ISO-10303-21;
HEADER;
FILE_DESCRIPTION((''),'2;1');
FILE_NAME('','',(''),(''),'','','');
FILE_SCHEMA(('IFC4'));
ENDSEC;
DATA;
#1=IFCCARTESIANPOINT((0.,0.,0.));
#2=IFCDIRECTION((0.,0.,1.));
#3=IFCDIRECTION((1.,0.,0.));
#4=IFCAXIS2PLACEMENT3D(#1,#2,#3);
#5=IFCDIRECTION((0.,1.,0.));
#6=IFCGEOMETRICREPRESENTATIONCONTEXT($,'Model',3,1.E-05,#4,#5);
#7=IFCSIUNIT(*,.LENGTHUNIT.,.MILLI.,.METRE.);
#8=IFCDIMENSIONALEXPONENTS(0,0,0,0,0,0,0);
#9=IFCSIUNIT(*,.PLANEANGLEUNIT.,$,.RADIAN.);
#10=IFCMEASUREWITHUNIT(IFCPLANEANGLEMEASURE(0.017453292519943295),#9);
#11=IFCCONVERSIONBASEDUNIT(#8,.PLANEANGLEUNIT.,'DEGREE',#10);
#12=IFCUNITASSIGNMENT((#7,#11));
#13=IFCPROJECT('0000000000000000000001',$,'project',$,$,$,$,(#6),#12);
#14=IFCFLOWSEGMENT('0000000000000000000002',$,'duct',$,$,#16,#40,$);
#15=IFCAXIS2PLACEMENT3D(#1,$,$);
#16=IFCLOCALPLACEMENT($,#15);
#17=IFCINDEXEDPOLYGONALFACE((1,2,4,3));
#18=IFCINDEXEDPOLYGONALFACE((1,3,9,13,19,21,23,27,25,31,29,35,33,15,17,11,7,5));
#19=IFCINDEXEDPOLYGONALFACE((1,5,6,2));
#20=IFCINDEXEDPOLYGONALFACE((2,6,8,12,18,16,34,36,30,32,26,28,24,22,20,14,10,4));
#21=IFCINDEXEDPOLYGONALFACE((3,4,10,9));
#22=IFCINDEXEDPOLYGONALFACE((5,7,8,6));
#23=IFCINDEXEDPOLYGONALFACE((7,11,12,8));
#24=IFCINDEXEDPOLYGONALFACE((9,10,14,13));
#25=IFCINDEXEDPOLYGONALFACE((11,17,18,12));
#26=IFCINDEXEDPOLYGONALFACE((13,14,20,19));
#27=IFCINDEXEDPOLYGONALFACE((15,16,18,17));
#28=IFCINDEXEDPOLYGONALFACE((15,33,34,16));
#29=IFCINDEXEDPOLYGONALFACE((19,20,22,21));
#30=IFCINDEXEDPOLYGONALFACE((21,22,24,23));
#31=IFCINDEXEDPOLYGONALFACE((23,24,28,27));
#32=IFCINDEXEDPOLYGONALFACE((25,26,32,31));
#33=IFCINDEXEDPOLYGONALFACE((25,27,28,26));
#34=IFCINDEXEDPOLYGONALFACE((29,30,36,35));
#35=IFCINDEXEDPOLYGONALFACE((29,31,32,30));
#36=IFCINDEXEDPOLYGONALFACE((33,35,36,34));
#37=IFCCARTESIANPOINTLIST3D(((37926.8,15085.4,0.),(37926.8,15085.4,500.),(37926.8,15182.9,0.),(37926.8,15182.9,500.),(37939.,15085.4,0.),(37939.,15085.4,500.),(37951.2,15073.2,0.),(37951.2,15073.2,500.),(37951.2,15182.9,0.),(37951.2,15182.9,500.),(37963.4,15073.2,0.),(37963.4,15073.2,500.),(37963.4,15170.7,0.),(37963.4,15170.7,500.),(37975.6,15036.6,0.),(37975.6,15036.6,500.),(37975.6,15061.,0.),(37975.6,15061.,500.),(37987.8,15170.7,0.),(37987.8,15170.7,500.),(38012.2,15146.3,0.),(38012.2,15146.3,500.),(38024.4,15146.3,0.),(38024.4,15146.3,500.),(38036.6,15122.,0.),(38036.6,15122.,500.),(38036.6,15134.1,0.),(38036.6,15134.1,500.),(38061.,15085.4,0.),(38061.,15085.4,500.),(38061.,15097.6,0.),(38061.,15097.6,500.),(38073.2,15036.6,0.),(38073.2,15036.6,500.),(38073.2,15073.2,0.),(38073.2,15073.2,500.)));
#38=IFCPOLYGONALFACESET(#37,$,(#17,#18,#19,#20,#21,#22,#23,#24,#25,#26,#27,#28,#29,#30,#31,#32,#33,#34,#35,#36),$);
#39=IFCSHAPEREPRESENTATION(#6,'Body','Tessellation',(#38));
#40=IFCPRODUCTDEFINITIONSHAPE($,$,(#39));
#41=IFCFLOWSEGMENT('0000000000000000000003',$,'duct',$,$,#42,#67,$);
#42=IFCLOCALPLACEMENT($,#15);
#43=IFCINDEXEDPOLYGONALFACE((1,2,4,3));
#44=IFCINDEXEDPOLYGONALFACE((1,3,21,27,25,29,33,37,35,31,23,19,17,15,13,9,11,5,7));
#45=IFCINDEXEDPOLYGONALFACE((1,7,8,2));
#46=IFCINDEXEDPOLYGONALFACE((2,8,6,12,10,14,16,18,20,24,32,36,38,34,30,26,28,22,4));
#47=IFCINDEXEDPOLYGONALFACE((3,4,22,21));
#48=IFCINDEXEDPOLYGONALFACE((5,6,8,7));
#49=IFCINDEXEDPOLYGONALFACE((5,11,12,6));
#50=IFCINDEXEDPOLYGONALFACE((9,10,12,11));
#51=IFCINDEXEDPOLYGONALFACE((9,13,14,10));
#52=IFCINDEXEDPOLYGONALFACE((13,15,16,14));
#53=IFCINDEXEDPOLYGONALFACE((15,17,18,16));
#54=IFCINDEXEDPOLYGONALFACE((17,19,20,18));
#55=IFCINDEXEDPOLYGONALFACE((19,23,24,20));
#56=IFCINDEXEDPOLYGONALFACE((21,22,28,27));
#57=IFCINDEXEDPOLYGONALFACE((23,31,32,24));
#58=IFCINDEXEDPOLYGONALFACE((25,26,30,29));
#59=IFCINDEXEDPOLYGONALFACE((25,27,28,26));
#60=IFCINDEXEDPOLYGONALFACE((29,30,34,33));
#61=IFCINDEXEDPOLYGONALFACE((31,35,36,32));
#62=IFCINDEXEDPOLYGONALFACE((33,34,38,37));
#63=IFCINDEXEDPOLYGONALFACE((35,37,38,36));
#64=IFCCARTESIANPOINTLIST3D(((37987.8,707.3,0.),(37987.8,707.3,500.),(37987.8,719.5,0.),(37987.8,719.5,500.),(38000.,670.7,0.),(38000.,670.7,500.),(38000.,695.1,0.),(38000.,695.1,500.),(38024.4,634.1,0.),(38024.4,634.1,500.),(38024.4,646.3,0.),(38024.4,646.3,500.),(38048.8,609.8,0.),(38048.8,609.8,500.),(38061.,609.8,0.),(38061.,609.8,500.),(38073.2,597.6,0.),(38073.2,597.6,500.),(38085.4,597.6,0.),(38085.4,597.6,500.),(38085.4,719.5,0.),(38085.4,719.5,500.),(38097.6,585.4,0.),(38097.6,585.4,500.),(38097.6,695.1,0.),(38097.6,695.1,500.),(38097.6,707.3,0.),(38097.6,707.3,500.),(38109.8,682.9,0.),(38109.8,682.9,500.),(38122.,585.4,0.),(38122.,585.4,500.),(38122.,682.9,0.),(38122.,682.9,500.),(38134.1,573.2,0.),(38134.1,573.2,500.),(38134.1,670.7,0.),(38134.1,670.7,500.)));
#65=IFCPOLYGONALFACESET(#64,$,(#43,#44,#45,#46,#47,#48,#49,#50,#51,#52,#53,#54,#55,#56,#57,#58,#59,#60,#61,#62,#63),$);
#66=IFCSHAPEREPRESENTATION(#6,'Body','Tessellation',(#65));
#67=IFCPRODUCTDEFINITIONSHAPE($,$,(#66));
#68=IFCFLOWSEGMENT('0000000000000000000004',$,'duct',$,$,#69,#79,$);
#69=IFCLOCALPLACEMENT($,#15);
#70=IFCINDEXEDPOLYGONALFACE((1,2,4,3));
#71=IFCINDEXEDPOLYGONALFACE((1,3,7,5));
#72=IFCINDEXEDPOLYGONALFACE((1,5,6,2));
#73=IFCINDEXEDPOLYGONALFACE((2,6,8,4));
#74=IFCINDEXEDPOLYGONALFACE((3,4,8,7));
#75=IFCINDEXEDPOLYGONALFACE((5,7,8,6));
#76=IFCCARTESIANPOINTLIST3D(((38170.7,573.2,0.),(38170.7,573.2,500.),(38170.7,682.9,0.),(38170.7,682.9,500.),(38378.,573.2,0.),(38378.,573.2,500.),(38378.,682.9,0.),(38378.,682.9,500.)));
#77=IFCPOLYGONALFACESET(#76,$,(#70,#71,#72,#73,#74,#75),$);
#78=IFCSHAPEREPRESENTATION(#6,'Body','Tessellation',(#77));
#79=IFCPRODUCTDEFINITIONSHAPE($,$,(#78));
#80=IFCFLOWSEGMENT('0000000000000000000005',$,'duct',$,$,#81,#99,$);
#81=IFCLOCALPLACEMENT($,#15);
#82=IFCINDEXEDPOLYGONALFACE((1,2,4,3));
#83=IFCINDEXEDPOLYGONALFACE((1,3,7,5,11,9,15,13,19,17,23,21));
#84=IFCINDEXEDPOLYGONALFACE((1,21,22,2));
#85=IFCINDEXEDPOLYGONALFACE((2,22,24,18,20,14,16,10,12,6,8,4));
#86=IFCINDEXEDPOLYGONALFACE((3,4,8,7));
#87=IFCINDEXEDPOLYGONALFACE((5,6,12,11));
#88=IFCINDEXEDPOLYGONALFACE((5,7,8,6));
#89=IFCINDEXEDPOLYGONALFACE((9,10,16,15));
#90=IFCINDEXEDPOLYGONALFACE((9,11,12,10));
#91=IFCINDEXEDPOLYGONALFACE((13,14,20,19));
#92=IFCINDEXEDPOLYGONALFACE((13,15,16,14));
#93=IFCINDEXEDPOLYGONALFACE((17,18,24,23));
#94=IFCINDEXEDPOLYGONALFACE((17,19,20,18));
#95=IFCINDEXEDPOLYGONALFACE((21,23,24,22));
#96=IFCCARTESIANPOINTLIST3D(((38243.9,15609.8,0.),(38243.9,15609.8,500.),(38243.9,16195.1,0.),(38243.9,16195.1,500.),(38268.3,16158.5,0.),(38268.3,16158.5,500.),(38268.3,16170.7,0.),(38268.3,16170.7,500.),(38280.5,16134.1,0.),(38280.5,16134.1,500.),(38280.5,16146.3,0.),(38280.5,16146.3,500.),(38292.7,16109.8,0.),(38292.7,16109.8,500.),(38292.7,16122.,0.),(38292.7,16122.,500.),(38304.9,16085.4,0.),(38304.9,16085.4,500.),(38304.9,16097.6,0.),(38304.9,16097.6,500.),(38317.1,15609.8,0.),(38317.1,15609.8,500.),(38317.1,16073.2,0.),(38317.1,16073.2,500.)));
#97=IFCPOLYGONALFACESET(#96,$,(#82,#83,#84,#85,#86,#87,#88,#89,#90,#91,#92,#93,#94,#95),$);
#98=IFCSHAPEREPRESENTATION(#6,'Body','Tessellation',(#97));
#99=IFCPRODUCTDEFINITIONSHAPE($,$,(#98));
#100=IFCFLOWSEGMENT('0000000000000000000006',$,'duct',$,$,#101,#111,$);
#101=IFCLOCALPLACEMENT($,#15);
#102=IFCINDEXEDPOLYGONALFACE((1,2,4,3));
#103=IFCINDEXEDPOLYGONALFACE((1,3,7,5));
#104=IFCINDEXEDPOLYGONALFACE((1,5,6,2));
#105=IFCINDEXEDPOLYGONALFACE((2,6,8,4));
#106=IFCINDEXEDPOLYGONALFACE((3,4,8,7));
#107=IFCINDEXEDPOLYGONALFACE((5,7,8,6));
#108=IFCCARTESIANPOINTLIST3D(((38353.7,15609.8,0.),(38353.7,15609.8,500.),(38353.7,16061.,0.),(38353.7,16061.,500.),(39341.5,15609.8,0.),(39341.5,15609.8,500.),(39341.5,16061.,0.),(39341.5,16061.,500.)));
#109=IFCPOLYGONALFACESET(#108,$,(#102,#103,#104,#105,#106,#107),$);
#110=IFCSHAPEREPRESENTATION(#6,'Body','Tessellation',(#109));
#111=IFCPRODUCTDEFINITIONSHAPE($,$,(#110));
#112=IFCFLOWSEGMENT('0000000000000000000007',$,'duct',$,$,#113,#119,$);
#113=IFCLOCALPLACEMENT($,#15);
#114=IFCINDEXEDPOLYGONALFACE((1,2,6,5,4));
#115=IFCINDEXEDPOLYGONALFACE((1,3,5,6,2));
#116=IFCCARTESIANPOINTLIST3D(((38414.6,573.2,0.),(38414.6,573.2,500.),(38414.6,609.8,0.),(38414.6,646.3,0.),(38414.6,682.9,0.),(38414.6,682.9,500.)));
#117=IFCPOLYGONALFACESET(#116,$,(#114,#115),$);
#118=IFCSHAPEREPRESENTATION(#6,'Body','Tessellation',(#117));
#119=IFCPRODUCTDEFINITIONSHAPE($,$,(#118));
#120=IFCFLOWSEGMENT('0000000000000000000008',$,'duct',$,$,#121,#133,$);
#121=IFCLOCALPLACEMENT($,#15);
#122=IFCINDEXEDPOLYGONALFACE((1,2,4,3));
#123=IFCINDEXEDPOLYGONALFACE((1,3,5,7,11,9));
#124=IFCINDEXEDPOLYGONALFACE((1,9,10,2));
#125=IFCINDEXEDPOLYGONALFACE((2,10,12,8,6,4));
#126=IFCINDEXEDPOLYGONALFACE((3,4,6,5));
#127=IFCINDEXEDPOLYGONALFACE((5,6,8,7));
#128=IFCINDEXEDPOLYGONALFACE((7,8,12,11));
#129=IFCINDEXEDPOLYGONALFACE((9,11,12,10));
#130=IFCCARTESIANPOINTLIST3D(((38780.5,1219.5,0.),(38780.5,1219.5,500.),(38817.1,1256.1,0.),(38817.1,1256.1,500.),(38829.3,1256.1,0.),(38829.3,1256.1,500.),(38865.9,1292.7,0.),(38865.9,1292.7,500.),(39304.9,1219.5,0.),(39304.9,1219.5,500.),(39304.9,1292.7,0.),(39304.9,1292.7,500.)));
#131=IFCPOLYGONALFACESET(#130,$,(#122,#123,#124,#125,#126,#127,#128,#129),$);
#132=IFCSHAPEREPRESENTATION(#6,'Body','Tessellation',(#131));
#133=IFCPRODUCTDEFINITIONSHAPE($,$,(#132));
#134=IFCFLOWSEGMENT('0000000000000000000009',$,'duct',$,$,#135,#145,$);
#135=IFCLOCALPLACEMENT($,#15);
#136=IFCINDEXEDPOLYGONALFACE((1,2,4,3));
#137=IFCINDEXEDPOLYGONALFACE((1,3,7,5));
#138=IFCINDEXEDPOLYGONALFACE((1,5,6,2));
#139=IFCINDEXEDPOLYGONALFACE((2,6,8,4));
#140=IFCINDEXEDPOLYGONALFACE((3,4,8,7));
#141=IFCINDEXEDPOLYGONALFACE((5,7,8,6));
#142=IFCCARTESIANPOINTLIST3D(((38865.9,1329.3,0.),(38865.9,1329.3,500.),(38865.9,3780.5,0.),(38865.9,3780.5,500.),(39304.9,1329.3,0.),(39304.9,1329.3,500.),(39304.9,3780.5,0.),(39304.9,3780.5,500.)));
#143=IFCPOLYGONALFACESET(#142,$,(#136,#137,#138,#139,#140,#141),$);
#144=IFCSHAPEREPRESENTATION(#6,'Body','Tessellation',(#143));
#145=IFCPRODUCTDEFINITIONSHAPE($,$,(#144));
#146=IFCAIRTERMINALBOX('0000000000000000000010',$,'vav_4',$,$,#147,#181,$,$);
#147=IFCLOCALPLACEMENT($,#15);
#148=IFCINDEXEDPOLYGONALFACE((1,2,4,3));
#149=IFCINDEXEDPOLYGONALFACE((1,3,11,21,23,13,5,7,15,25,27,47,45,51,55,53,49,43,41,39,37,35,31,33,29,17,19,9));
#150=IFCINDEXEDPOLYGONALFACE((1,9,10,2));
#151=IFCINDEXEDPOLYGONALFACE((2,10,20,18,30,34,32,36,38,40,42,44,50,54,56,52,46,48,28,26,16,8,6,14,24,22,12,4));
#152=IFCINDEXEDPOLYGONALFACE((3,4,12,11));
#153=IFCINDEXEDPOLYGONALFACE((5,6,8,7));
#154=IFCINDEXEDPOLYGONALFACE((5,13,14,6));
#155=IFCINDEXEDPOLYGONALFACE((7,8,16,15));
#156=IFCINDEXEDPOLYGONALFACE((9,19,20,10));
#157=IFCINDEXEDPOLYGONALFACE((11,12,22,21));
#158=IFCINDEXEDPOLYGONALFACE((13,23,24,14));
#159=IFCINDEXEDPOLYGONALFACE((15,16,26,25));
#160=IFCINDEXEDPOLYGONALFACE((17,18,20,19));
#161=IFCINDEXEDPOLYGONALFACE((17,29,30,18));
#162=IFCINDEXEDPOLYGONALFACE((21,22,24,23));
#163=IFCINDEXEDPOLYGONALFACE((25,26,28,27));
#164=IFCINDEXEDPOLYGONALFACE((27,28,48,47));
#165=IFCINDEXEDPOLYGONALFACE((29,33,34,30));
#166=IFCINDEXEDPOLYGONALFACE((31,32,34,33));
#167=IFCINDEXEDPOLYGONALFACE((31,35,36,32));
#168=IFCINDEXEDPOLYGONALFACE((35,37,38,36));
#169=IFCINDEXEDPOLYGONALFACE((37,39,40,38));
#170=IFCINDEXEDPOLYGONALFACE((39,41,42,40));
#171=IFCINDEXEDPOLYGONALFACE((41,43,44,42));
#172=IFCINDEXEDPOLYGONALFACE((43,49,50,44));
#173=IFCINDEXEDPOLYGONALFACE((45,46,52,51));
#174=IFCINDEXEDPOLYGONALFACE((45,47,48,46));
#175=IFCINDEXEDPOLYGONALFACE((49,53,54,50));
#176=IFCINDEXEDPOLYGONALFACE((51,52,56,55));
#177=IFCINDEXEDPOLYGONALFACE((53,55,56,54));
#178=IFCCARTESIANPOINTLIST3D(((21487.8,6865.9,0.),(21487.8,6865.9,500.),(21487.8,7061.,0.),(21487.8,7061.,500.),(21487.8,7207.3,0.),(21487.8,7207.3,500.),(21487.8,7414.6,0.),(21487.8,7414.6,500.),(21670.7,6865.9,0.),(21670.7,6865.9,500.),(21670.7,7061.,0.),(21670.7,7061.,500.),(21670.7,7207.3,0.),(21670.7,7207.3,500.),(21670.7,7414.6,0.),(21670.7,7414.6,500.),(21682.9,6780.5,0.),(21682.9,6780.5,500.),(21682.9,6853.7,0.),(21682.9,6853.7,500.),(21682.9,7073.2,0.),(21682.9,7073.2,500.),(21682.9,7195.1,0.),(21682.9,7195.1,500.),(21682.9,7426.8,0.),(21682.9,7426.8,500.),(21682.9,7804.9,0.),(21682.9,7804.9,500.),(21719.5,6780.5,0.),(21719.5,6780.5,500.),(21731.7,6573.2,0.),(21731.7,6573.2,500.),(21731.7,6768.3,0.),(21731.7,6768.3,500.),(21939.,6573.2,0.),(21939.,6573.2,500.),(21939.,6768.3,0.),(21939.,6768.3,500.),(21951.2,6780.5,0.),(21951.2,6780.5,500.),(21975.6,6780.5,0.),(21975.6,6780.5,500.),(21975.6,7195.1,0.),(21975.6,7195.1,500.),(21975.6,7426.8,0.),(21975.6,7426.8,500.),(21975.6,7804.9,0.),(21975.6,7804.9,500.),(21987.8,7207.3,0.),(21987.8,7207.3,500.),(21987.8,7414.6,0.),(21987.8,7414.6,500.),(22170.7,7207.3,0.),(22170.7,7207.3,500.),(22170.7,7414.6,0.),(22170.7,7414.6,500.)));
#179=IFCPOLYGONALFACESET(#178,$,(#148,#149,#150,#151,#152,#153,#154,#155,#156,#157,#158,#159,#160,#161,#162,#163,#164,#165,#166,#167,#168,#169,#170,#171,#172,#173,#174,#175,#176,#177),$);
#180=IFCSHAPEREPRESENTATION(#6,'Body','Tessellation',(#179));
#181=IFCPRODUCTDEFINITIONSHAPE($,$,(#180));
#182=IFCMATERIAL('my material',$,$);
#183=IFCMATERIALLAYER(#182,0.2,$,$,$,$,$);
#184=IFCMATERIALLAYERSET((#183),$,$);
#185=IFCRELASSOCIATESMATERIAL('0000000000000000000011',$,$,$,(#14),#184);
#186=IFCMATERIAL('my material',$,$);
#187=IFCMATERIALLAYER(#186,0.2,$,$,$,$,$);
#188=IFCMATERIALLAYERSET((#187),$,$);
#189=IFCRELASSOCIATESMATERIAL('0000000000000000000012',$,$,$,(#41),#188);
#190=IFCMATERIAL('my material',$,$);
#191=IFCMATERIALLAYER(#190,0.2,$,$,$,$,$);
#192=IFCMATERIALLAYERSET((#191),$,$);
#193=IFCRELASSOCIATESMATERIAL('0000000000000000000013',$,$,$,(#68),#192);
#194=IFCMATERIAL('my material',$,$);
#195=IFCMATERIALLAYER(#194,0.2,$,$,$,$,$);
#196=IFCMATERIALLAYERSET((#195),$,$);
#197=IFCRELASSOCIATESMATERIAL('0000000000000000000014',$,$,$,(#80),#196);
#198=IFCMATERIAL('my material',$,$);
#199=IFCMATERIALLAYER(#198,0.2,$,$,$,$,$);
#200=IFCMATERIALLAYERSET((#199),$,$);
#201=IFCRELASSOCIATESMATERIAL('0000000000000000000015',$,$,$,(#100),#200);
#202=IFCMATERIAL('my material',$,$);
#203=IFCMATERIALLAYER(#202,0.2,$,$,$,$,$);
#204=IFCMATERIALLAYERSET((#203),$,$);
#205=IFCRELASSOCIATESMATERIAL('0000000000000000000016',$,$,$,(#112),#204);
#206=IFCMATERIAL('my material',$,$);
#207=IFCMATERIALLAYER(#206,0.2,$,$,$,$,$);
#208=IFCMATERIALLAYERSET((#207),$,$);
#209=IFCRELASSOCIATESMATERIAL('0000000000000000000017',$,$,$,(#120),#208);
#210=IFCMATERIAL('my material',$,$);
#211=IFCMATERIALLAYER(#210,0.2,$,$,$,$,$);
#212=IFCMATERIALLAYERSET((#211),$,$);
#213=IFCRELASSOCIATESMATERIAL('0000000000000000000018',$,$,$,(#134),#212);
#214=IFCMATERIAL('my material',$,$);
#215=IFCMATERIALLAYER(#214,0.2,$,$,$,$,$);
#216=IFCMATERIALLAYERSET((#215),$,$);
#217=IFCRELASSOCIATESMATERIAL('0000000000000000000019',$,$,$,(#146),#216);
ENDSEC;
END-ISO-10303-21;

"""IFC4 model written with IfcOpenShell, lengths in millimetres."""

from ifc_helpers import new_model, entity, si_unit, converted_unit, direction, origin_with_axes, place, context, project, polyline, outline, extrude, material, layer, layer_set, layer_usage, element, save


model = new_model("IFC4")

# Units and contexts
model_context = context("Model", 3, precision=1e-05, world=origin_with_axes(), true_north=direction((0.0, 1.0, 0.0)))
ifc_project = project(units=[si_unit("LENGTHUNIT", "METRE", prefix="MILLI"), converted_unit("PLANEANGLEUNIT", "DEGREE", entity("IfcPlaneAngleMeasure", 0.017453292519943295), si_unit("PLANEANGLEUNIT", "RADIAN"), dimensions=[0, 0, 0, 0, 0, 0, 0])], contexts=[model_context])

# Flow segments
ifc_material_1 = material(Name="my material")
ifc_layer_1 = layer(ifc_material_1, 0.2)
ifc_layer_set_1 = layer_set([ifc_layer_1])
ifc_layer_usage_1 = layer_usage(ifc_layer_set_1, "AXIS2", "POSITIVE", -0.1)
flow_segment_1_placement = place(None, origin_with_axes())
element("IfcFlowSegment", 1, at=flow_segment_1_placement, material=ifc_layer_usage_1, Name="duct", context=model_context, shape_type="SweptSolid", body=[
    extrude(outline(polyline([(37926.8, 15085.4), (37939.0, 15085.4), (37951.2, 15073.2), (37963.4, 15073.2), (37975.6, 15061.0), (37975.6, 15036.6), (38073.2, 15036.6), (38073.2, 15073.2), (38061.0, 15085.4), (38061.0, 15097.6), (38036.6, 15122.0), (38036.6, 15134.1), (38024.4, 15146.3), (38012.2, 15146.3), (37987.8, 15170.7), (37963.4, 15170.7), (37951.2, 15182.9), (37926.8, 15182.9), (37926.8, 15085.4)])), origin_with_axes(), (0.0, 0.0, 1.0), 500.0),
])
ifc_material_2 = material(Name="my material")
ifc_layer_2 = layer(ifc_material_2, 0.2)
ifc_layer_set_2 = layer_set([ifc_layer_2])
ifc_layer_usage_2 = layer_usage(ifc_layer_set_2, "AXIS2", "POSITIVE", -0.1)
flow_segment_2_placement = place(None, origin_with_axes())
element("IfcFlowSegment", 2, at=flow_segment_2_placement, material=ifc_layer_usage_2, Name="duct", context=model_context, shape_type="SweptSolid", body=[
    extrude(outline(polyline([(37987.8, 707.3), (38000.0, 695.1), (38000.0, 670.7), (38024.4, 646.3), (38024.4, 634.1), (38048.8, 609.8), (38061.0, 609.8), (38073.2, 597.6), (38085.4, 597.6), (38097.6, 585.4), (38122.0, 585.4), (38134.1, 573.2), (38134.1, 670.7), (38122.0, 682.9), (38109.8, 682.9), (38097.6, 695.1), (38097.6, 707.3), (38085.4, 719.5), (37987.8, 719.5), (37987.8, 707.3)])), origin_with_axes(), (0.0, 0.0, 1.0), 500.0),
])
ifc_material_3 = material(Name="my material")
ifc_layer_3 = layer(ifc_material_3, 0.2)
ifc_layer_set_3 = layer_set([ifc_layer_3])
ifc_layer_usage_3 = layer_usage(ifc_layer_set_3, "AXIS2", "POSITIVE", -0.1)
flow_segment_3_placement = place(None, origin_with_axes())
element("IfcFlowSegment", 3, at=flow_segment_3_placement, material=ifc_layer_usage_3, Name="duct", context=model_context, shape_type="SweptSolid", body=[
    extrude(outline(polyline([(38170.7, 573.2), (38378.0, 573.2), (38378.0, 682.9), (38170.7, 682.9), (38170.7, 573.2)])), origin_with_axes(), (0.0, 0.0, 1.0), 500.0),
])
ifc_material_4 = material(Name="my material")
ifc_layer_4 = layer(ifc_material_4, 0.2)
ifc_layer_set_4 = layer_set([ifc_layer_4])
ifc_layer_usage_4 = layer_usage(ifc_layer_set_4, "AXIS2", "POSITIVE", -0.1)
flow_segment_4_placement = place(None, origin_with_axes())
element("IfcFlowSegment", 4, at=flow_segment_4_placement, material=ifc_layer_usage_4, Name="duct", context=model_context, shape_type="SweptSolid", body=[
    extrude(outline(polyline([(38243.9, 15609.8), (38317.1, 15609.8), (38317.1, 16073.2), (38304.9, 16085.4), (38304.9, 16097.6), (38292.7, 16109.8), (38292.7, 16122.0), (38280.5, 16134.1), (38280.5, 16146.3), (38268.3, 16158.5), (38268.3, 16170.7), (38243.9, 16195.1), (38243.9, 16207.3), (38243.9, 15609.8)])), origin_with_axes(), (0.0, 0.0, 1.0), 500.0),
])
ifc_material_5 = material(Name="my material")
ifc_layer_5 = layer(ifc_material_5, 0.2)
ifc_layer_set_5 = layer_set([ifc_layer_5])
ifc_layer_usage_5 = layer_usage(ifc_layer_set_5, "AXIS2", "POSITIVE", -0.1)
flow_segment_5_placement = place(None, origin_with_axes())
element("IfcFlowSegment", 5, at=flow_segment_5_placement, material=ifc_layer_usage_5, Name="duct", context=model_context, shape_type="SweptSolid", body=[
    extrude(outline(polyline([(38353.7, 15609.8), (39341.5, 15609.8), (39341.5, 16061.0), (38353.7, 16061.0), (38353.7, 15609.8)])), origin_with_axes(), (0.0, 0.0, 1.0), 500.0),
])
ifc_material_6 = material(Name="my material")
ifc_layer_6 = layer(ifc_material_6, 0.2)
ifc_layer_set_6 = layer_set([ifc_layer_6])
ifc_layer_usage_6 = layer_usage(ifc_layer_set_6, "AXIS2", "POSITIVE", -0.1)
flow_segment_6_placement = place(None, origin_with_axes())
element("IfcFlowSegment", 6, at=flow_segment_6_placement, material=ifc_layer_usage_6, Name="duct", context=model_context, shape_type="SweptSolid", body=[
    extrude(outline(polyline([(38414.6, 573.2), (38414.6, 682.9), (38414.6, 573.2)])), origin_with_axes(), (0.0, 0.0, 1.0), 500.0),
])
ifc_material_7 = material(Name="my material")
ifc_layer_7 = layer(ifc_material_7, 0.2)
ifc_layer_set_7 = layer_set([ifc_layer_7])
ifc_layer_usage_7 = layer_usage(ifc_layer_set_7, "AXIS2", "POSITIVE", -0.1)
flow_segment_7_placement = place(None, origin_with_axes())
element("IfcFlowSegment", 7, at=flow_segment_7_placement, material=ifc_layer_usage_7, Name="duct", context=model_context, shape_type="SweptSolid", body=[
    extrude(outline(polyline([(38780.5, 1219.5), (39304.9, 1219.5), (39304.9, 1292.7), (38865.9, 1292.7), (38829.3, 1256.1), (38817.1, 1256.1), (38780.5, 1219.5)])), origin_with_axes(), (0.0, 0.0, 1.0), 500.0),
])
ifc_material_8 = material(Name="my material")
ifc_layer_8 = layer(ifc_material_8, 0.2)
ifc_layer_set_8 = layer_set([ifc_layer_8])
ifc_layer_usage_8 = layer_usage(ifc_layer_set_8, "AXIS2", "POSITIVE", -0.1)
flow_segment_8_placement = place(None, origin_with_axes())
element("IfcFlowSegment", 8, at=flow_segment_8_placement, material=ifc_layer_usage_8, Name="duct", context=model_context, shape_type="SweptSolid", body=[
    extrude(outline(polyline([(38865.9, 1329.3), (39304.9, 1329.3), (39304.9, 3780.5), (38865.9, 3780.5), (38865.9, 1329.3)])), origin_with_axes(), (0.0, 0.0, 1.0), 500.0),
])

# Air terminal box
ifc_material_9 = material(Name="my material")
ifc_layer_9 = layer(ifc_material_9, 0.2)
ifc_layer_set_9 = layer_set([ifc_layer_9])
ifc_layer_usage_9 = layer_usage(ifc_layer_set_9, "AXIS2", "POSITIVE", -0.1)
air_terminal_box_1_placement = place(None, origin_with_axes())
element("IfcAirTerminalBox", 9, at=air_terminal_box_1_placement, material=ifc_layer_usage_9, Name="vav_4", context=model_context, shape_type="SweptSolid", body=[
    extrude(outline(polyline([(21487.8, 6865.9), (21670.7, 6865.9), (21682.9, 6853.7), (21682.9, 6780.5), (21719.5, 6780.5), (21731.7, 6768.3), (21731.7, 6573.2), (21939.0, 6573.2), (21939.0, 6768.3), (21951.2, 6780.5), (21975.6, 6780.5), (21975.6, 7195.1), (21987.8, 7207.3), (22170.7, 7207.3), (22170.7, 7414.6), (21987.8, 7414.6), (21975.6, 7426.8), (21975.6, 7804.9), (21682.9, 7804.9), (21682.9, 7426.8), (21670.7, 7414.6), (21487.8, 7414.6), (21487.8, 7207.3), (21670.7, 7207.3), (21682.9, 7195.1), (21682.9, 7073.2), (21670.7, 7061.0), (21487.8, 7061.0), (21487.8, 6865.9)])), origin_with_axes(), (0.0, 0.0, 1.0), 500.0),
])

save(model, "model.ifc")
